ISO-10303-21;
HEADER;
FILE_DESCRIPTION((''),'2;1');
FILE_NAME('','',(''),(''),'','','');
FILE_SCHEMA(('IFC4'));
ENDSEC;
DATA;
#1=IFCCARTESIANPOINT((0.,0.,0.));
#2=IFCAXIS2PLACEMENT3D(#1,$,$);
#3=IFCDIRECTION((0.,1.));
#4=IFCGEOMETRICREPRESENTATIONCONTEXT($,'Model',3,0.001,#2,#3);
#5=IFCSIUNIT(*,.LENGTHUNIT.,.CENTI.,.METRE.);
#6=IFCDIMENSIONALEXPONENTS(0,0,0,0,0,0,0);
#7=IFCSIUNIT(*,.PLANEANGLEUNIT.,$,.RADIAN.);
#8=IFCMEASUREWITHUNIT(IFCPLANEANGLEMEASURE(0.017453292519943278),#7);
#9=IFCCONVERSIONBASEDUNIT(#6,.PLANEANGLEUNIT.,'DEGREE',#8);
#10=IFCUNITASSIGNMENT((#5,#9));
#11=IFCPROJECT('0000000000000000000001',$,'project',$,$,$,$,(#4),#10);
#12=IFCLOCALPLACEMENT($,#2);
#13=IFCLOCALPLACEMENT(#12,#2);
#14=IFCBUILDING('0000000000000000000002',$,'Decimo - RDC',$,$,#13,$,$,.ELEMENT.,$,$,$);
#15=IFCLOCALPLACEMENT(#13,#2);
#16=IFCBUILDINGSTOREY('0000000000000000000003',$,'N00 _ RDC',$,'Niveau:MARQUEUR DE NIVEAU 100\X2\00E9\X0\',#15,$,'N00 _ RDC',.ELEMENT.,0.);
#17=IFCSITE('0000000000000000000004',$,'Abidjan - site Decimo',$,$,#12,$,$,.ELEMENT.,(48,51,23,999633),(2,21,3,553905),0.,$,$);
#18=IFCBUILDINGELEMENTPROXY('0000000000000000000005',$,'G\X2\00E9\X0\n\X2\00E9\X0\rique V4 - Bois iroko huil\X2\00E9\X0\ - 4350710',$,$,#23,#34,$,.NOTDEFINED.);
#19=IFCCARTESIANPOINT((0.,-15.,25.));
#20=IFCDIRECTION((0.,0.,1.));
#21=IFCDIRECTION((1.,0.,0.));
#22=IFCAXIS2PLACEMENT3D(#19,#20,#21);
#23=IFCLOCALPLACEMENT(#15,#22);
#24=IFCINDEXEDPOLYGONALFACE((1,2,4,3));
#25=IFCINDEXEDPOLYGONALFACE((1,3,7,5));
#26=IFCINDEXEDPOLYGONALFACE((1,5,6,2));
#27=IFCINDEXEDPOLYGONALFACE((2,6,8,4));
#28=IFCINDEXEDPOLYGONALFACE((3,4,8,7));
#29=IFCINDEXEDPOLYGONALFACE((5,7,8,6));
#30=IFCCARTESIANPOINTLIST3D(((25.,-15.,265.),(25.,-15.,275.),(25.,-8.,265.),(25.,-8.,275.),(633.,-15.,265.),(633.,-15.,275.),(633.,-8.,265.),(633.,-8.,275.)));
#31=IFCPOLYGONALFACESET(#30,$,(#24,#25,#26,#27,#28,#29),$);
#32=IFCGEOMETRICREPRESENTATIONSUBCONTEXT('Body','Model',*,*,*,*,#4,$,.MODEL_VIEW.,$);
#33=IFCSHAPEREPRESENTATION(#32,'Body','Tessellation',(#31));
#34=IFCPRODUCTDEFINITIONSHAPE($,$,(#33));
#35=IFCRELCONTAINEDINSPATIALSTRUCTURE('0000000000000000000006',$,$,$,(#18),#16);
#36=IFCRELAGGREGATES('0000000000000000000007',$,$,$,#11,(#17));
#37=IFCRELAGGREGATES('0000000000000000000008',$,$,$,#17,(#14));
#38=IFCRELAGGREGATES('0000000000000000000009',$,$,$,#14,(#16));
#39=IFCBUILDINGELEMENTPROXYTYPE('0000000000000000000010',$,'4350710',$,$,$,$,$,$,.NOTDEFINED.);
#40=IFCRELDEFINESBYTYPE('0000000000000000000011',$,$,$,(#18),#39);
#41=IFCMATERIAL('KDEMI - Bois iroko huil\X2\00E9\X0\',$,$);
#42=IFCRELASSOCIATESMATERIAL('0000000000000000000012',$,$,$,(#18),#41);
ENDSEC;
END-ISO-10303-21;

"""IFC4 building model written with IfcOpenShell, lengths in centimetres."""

from ifc_helpers import new_model, entity, si_unit, converted_unit, direction, frame, frame_2d, origin, place, context, subcontext, project, spatial, rectangle, extrude, material, type_object, element, save


model = new_model("IFC4")

# Units and contexts
model_context = context("Model", 3, precision=0.001, world=origin(), true_north=direction((0.0, 1.0)))
body_context = subcontext(model_context, "Body", "Model", "MODEL_VIEW")
ifc_project = project(units=[si_unit("LENGTHUNIT", "METRE", prefix="CENTI"), converted_unit("PLANEANGLEUNIT", "DEGREE", entity("IfcPlaneAngleMeasure", 0.017453292519943278), si_unit("PLANEANGLEUNIT", "RADIAN"), dimensions=[0, 0, 0, 0, 0, 0, 0])], contexts=[model_context])

# Site, building, storey
site_placement = place(None, origin())
site = spatial("IfcSite", under=ifc_project, at=site_placement, Name="Abidjan - site Decimo", CompositionType="ELEMENT", RefLatitude=(48, 51, 23, 999633), RefLongitude=(2, 21, 3, 553905), RefElevation=0.0)
building_placement = place(site_placement, origin())
building = spatial("IfcBuilding", under=site, at=building_placement, Name="Decimo - RDC", CompositionType="ELEMENT")
storey_placement = place(building_placement, origin())
storey = spatial("IfcBuildingStorey", under=building, at=storey_placement, Name="N00 _ RDC", ObjectType="Niveau:MARQUEUR DE NIVEAU 100é", LongName="N00 _ RDC", CompositionType="ELEMENT", Elevation=0.0)

# Shared definitions
ifc_material_1 = material(Name="KDEMI - Bois iroko huilé")

# Building element proxy
building_element_proxy_type_1 = type_object("IfcBuildingElementProxyType", Name="4350710", PredefinedType="NOTDEFINED")
proxy_1_placement = place(storey_placement, frame((0.0, -15.0, 25.0), z_axis=(0.0, 0.0, 1.0), x_axis=(1.0, 0.0, 0.0)))
element("IfcBuildingElementProxy", 1, at=proxy_1_placement, inside=storey, type_object=building_element_proxy_type_1, material=ifc_material_1, Name="Générique V4 - Bois iroko huilé - 4350710", PredefinedType="NOTDEFINED", context=body_context, shape_type="SweptSolid", body=[
    extrude(rectangle(XDim=608.0, YDim=7.0, at=frame_2d((0.0, 0.0), x_axis=(1.0, 0.0))), frame((329.0, -11.5, 265.0)), (0.0, 0.0, 1.0), 10.0),
])

save(model, "model.ifc")
